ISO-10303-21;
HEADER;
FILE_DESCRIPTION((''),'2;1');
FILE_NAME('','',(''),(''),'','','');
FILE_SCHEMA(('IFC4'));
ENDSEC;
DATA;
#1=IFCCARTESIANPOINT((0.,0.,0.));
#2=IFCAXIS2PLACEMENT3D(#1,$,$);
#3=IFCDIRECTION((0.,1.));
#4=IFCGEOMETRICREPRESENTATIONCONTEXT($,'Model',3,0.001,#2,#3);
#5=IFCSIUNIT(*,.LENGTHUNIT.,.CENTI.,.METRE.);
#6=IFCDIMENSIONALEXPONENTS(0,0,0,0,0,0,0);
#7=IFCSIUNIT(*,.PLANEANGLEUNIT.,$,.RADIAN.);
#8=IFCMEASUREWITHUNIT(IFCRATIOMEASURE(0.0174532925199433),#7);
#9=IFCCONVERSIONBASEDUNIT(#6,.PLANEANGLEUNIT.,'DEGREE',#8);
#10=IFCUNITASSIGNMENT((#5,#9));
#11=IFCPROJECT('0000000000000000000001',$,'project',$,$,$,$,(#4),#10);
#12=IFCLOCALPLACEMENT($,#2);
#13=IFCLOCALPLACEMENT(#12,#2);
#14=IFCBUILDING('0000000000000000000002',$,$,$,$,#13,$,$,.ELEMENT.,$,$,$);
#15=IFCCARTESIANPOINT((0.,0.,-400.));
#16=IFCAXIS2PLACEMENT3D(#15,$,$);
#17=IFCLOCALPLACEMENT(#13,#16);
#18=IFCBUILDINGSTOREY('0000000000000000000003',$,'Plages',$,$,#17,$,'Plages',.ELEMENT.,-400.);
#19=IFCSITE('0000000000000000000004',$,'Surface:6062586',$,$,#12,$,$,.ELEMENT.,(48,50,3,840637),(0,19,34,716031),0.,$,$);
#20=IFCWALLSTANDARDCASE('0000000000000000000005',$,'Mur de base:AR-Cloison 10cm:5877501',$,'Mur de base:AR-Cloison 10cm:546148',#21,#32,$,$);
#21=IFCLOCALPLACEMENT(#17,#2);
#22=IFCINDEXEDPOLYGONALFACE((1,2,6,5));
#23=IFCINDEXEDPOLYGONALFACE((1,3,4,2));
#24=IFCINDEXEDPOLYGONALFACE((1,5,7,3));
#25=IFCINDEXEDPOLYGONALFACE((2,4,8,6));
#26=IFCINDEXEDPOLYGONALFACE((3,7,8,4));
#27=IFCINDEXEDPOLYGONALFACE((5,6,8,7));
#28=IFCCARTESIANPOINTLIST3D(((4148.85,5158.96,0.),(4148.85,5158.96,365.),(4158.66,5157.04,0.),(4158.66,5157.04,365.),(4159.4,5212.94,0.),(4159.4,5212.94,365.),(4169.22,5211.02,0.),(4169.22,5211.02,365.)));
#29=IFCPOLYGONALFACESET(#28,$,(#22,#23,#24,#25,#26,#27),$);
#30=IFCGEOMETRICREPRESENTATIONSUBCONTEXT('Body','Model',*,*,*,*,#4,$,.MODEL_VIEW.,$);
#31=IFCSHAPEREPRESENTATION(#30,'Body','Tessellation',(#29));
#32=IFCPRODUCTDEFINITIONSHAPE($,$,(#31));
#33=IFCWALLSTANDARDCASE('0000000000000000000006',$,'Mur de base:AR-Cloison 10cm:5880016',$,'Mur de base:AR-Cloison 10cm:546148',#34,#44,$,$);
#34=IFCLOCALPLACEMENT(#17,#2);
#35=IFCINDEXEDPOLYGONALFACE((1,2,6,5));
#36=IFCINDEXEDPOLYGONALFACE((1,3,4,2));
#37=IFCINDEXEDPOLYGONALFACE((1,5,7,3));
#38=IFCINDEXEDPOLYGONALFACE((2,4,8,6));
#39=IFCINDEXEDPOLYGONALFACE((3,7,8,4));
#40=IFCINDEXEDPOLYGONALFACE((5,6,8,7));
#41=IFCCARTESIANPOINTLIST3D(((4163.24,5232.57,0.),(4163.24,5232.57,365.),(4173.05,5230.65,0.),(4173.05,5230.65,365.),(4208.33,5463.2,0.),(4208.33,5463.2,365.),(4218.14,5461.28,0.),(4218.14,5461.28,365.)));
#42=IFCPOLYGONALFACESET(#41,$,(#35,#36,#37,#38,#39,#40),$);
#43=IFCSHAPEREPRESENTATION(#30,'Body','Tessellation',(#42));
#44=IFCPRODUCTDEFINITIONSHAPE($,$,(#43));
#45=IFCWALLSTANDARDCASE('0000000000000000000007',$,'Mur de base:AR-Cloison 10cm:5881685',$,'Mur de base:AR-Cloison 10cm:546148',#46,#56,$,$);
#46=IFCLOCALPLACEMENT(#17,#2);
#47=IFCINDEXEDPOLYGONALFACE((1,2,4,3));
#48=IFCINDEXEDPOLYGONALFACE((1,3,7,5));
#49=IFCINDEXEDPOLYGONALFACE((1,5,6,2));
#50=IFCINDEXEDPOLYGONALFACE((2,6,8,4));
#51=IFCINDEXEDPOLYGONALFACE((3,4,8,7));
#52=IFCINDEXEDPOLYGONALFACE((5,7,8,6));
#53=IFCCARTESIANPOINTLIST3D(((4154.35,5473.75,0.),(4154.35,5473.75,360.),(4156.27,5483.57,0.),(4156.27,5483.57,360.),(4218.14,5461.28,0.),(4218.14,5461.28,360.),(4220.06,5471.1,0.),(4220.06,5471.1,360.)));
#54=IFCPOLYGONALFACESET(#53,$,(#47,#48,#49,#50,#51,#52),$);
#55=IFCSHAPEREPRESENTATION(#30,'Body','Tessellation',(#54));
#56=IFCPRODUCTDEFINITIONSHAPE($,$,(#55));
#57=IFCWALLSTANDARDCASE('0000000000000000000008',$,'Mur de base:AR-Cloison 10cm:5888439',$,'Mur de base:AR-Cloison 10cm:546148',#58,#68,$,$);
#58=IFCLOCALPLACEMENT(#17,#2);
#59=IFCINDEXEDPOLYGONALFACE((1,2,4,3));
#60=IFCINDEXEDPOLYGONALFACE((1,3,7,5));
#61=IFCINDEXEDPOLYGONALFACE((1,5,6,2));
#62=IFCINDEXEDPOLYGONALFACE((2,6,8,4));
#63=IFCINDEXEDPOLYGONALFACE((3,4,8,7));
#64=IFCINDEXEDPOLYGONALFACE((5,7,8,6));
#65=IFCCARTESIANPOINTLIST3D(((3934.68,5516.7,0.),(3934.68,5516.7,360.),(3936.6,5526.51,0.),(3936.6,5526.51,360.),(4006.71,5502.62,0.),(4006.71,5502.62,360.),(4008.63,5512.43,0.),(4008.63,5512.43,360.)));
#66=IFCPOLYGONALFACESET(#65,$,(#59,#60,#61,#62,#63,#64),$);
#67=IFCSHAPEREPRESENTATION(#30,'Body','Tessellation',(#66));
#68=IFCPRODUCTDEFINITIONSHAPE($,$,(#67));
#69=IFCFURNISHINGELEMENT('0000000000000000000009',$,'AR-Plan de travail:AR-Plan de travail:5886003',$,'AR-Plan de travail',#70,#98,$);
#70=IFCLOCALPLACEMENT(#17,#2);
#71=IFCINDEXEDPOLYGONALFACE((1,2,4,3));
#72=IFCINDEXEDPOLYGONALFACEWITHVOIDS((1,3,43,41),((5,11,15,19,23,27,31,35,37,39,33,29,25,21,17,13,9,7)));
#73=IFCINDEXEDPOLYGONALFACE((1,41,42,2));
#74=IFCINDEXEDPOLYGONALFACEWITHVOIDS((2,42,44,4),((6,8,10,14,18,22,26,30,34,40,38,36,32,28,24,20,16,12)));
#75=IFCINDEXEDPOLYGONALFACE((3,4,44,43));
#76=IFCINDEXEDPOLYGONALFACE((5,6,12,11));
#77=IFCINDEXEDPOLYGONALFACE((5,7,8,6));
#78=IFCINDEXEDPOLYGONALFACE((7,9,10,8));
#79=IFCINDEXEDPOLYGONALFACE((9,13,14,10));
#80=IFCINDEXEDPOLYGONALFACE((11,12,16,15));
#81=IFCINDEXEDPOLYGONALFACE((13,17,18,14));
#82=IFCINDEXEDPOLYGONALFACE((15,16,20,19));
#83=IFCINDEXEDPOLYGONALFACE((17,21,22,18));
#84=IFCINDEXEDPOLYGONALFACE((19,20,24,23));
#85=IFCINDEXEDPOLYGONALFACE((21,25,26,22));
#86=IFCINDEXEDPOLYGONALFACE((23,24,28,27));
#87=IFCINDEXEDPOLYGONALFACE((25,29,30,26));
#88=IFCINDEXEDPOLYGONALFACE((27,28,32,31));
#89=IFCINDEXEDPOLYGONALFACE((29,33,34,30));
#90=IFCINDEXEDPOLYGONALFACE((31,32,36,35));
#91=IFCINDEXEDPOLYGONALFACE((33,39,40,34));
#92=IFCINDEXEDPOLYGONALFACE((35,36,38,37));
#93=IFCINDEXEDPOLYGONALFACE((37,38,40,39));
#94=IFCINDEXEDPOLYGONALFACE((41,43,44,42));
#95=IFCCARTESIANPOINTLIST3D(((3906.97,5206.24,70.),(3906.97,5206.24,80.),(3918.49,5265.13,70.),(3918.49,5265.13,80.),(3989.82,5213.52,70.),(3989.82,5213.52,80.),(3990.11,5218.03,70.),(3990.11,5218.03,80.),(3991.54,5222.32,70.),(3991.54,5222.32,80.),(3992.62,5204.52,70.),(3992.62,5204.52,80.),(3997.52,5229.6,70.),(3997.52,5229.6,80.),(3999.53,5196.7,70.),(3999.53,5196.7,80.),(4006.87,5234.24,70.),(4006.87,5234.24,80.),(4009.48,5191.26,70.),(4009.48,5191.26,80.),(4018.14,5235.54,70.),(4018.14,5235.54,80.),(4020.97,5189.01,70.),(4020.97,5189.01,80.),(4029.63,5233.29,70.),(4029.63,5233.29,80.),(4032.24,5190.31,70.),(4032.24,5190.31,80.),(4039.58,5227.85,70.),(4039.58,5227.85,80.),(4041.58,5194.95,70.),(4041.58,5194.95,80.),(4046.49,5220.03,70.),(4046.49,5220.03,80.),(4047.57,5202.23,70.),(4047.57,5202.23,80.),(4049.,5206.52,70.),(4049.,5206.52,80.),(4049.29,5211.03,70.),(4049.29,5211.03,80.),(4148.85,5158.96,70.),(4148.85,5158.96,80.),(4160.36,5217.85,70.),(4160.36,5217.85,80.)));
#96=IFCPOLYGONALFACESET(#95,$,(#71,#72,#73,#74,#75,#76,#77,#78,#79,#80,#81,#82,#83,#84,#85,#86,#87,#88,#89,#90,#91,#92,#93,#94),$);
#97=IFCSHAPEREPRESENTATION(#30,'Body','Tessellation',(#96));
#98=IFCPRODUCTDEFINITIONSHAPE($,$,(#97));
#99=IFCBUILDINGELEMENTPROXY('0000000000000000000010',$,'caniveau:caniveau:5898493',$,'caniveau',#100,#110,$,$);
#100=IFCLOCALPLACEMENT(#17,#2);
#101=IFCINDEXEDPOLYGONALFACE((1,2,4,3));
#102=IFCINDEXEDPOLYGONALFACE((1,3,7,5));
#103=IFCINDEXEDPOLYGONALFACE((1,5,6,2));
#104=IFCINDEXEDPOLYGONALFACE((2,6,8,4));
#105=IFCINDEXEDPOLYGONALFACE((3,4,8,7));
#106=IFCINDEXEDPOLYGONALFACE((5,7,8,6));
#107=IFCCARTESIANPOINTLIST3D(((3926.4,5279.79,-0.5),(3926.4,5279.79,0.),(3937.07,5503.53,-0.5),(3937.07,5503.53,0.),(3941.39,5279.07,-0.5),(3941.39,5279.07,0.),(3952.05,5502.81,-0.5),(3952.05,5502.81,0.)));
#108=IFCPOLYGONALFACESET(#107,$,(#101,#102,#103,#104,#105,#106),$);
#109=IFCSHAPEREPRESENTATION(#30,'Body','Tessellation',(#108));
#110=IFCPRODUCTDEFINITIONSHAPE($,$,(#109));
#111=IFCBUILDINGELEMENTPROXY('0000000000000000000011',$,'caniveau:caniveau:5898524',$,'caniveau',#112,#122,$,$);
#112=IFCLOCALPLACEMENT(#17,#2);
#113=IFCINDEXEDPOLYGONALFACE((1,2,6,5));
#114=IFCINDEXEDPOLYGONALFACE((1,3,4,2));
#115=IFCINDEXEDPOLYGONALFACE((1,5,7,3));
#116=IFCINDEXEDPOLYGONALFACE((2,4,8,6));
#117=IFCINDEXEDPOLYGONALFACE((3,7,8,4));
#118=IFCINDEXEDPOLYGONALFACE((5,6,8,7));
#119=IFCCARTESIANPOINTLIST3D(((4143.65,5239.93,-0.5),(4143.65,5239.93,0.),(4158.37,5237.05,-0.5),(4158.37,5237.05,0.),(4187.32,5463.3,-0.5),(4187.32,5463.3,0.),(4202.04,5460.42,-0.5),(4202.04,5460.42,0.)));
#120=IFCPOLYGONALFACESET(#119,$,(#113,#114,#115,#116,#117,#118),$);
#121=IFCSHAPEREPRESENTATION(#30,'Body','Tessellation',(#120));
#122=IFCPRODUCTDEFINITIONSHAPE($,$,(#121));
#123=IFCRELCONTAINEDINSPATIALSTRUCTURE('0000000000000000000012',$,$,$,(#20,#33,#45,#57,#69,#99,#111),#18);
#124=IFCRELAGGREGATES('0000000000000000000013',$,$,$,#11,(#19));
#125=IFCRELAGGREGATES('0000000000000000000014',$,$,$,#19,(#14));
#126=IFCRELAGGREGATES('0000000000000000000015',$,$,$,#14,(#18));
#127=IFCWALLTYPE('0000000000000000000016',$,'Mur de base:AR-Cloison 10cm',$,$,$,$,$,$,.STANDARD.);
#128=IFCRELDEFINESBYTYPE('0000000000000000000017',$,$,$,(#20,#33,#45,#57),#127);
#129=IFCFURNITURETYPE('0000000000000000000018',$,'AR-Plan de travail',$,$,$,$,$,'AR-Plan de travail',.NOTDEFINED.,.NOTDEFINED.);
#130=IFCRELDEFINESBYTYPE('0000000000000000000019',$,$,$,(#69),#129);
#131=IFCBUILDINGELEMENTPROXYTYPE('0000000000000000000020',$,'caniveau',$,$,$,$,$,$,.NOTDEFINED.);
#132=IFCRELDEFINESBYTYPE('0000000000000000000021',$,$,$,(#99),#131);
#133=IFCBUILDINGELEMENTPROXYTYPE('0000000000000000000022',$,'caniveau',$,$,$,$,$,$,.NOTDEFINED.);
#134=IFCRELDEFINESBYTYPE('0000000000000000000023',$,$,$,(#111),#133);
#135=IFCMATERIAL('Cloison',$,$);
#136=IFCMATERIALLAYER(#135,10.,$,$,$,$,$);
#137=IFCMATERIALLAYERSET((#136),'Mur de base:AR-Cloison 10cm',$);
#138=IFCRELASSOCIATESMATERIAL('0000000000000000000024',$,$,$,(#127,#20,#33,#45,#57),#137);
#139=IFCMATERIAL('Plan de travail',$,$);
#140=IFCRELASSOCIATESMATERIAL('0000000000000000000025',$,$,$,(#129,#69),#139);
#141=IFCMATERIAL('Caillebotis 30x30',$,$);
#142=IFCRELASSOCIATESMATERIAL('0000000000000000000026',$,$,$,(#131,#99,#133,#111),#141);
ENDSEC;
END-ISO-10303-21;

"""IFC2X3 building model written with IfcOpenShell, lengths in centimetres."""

from ifc_helpers import new_model, entity, si_unit, converted_unit, direction, frame, frame_2d, origin, origin_2d_with_axis, place, context, subcontext, project, spatial, polyline, rectangle, outline, extrude, source, transform, mapped, material, layer, layer_set, layer_usage, type_object, type_shapes, element, save


model = new_model("IFC2X3")

# Units and contexts
model_context = context("Model", 3, precision=0.001, world=origin(), true_north=direction((0.0, 1.0)))
body_context = subcontext(model_context, "Body", "Model", "MODEL_VIEW")
ifc_project = project(units=[si_unit("LENGTHUNIT", "METRE", prefix="CENTI"), converted_unit("PLANEANGLEUNIT", "DEGREE", entity("IfcRatioMeasure", 0.0174532925199433), si_unit("PLANEANGLEUNIT", "RADIAN"), dimensions=[0, 0, 0, 0, 0, 0, 0])], contexts=[model_context])

# Site, building, storey
site_placement = place(None, origin())
site = spatial("IfcSite", under=ifc_project, at=site_placement, Name="Surface:6062586", CompositionType="ELEMENT", RefLatitude=(48, 50, 3, 840637), RefLongitude=(0, 19, 34, 716031), RefElevation=0.0)
building_placement = place(site_placement, origin())
building = spatial("IfcBuilding", under=site, at=building_placement, CompositionType="ELEMENT")
storey_placement = place(building_placement, frame((0.0, 0.0, -400.0)))
storey = spatial("IfcBuildingStorey", under=building, at=storey_placement, Name="Plages", LongName="Plages", CompositionType="ELEMENT", Elevation=-400.0)

# Walls
ifc_material_1 = material(Name="Cloison")
ifc_layer_1 = layer(ifc_material_1, 10.0)
ifc_layer_set_1 = layer_set([ifc_layer_1], Name="Mur de base:AR-Cloison 10cm")
ifc_layer_usage_1 = layer_usage(ifc_layer_set_1, "AXIS2", "NEGATIVE", 5.0)
wall_type = type_object("IfcWallType", Name="Mur de base:AR-Cloison 10cm", PredefinedType="STANDARD", material=ifc_layer_set_1)
wall_1_placement = place(storey_placement, frame((4164.31, 5211.98, 0.0), z_axis=(0.0, 0.0, 1.0), x_axis=(-0.191861, -0.981422, 0.0)))
element("IfcWallStandardCase", 1, at=wall_1_placement, inside=storey, type_object=wall_type, material=ifc_layer_usage_1, Name="Mur de base:AR-Cloison 10cm:5877501", ObjectType="Mur de base:AR-Cloison 10cm:546148", context=body_context, shape_type="SweptSolid", body=[
    extrude(rectangle(XDim=55.0, YDim=10.0, at=frame_2d((27.5, 0.0), x_axis=(-1.0, 0.0))), origin(), (0.0, 0.0, 1.0), 365.0),
])
ifc_layer_usage_2 = layer_usage(ifc_layer_set_1, "AXIS2", "NEGATIVE", 5.0)
wall_2_placement = place(storey_placement, frame((4168.15, 5231.61, 0.0), z_axis=(0.0, 0.0, 1.0), x_axis=(0.191861, 0.981422, 0.0)))
element("IfcWallStandardCase", 2, at=wall_2_placement, inside=storey, type_object=wall_type, material=ifc_layer_usage_2, Name="Mur de base:AR-Cloison 10cm:5880016", ObjectType="Mur de base:AR-Cloison 10cm:546148", context=body_context, shape_type="SweptSolid", body=[
    extrude(rectangle(XDim=235.0, YDim=10.0, at=frame_2d((117.5, 0.0), x_axis=(-1.0, 0.0))), origin(), (0.0, 0.0, 1.0), 365.0),
])
ifc_layer_usage_3 = layer_usage(ifc_layer_set_1, "AXIS2", "NEGATIVE", 5.0)
wall_3_placement = place(storey_placement, frame((4219.1, 5466.19, 0.0), z_axis=(0.0, 0.0, 1.0), x_axis=(-0.981422, 0.191861, 0.0)))
element("IfcWallStandardCase", 3, at=wall_3_placement, inside=storey, type_object=wall_type, material=ifc_layer_usage_3, Name="Mur de base:AR-Cloison 10cm:5881685", ObjectType="Mur de base:AR-Cloison 10cm:546148", context=body_context, shape_type="SweptSolid", body=[
    extrude(rectangle(XDim=65.0, YDim=10.0, at=frame_2d((32.5, 0.0), x_axis=(-1.0, 0.0))), origin(), (0.0, 0.0, 1.0), 360.0),
])
ifc_layer_usage_4 = layer_usage(ifc_layer_set_1, "AXIS2", "NEGATIVE", 5.0)
wall_4_placement = place(storey_placement, frame((4007.67, 5507.52, 0.0), z_axis=(0.0, 0.0, 1.0), x_axis=(-0.981422, 0.191861, 0.0)))
element("IfcWallStandardCase", 4, at=wall_4_placement, inside=storey, type_object=wall_type, material=ifc_layer_usage_4, Name="Mur de base:AR-Cloison 10cm:5888439", ObjectType="Mur de base:AR-Cloison 10cm:546148", context=body_context, shape_type="SweptSolid", body=[
    extrude(rectangle(XDim=73.39, YDim=10.0, at=frame_2d((36.7, 0.0), x_axis=(-1.0, 0.0))), origin(), (0.0, 0.0, 1.0), 360.0),
])

# Furnishing element
ifc_material_2 = material(Name="Plan de travail")
furniture_type_1 = type_object("IfcFurnitureType", Name="AR-Plan de travail", ElementType="AR-Plan de travail", material=ifc_material_2)
shared_shape_1 = source(origin(), body_context, "Body", "SweptSolid", [
    extrude(outline(polyline([(-123.23, -30.0), (123.23, -30.0), (123.23, 30.0), (-123.23, 30.0), (-123.23, -30.0)]), holes=[polyline([(-43.9, -2.48), (-43.32, 2.0), (-38.84, 10.3), (-30.56, 16.64), (-19.75, 20.08), (-8.04, 20.08), (2.77, 16.64), (11.05, 10.3), (15.53, 2.0), (16.1, -2.48), (15.53, -6.97), (11.05, -15.26), (2.77, -21.61), (-8.04, -25.04), (-19.75, -25.04), (-30.56, -21.61), (-38.84, -15.26), (-43.32, -6.97), (-43.9, -2.48)])]), frame((126.69, 53.09, 0.0), z_axis=(0.0, 0.0, 1.0), x_axis=(0.981422, -0.191861, 0.0)), (0.0, 0.0, 1.0), 10.0),
])
type_shapes(furniture_type_1, [shared_shape_1])
furnishing_1_placement = place(storey_placement, frame((3906.97, 5158.96, 70.0)))
element("IfcFurnishingElement", 5, at=furnishing_1_placement, inside=storey, type_object=furniture_type_1, material=ifc_material_2, Name="AR-Plan de travail:AR-Plan de travail:5886003", ObjectType="AR-Plan de travail", context=body_context, shape_type="MappedRepresentation", body=[
    mapped(shared_shape_1, transform((0.0, 0.0, 0.0), scale=1.0)),
])

# Building element proxies
ifc_material_3 = material(Name="Caillebotis 30x30")
building_element_proxy_type_1 = type_object("IfcBuildingElementProxyType", Name="caniveau", PredefinedType="NOTDEFINED", material=ifc_material_3)
shared_shape_2 = source(origin(), body_context, "Body", "SweptSolid", [
    extrude(rectangle(XDim=15.0, YDim=224.0, at=origin_2d_with_axis()), frame((112.0, 7.5, -0.5), z_axis=(0.0, 0.0, 1.0), x_axis=(0.0, 1.0, 0.0)), (0.0, 0.0, 1.0), 0.5),
])
type_shapes(building_element_proxy_type_1, [shared_shape_2])
proxy_1_placement = place(storey_placement, frame((3937.07, 5503.53, 0.0), z_axis=(0.0, 0.0, 1.0), x_axis=(-0.047601, -0.998866, 0.0)))
element("IfcBuildingElementProxy", 6, at=proxy_1_placement, inside=storey, type_object=building_element_proxy_type_1, material=ifc_material_3, Name="caniveau:caniveau:5898493", ObjectType="caniveau", context=body_context, shape_type="MappedRepresentation", body=[
    mapped(shared_shape_2, transform((0.0, 0.0, 0.0), scale=1.0)),
])
building_element_proxy_type_2 = type_object("IfcBuildingElementProxyType", Name="caniveau", PredefinedType="NOTDEFINED", material=ifc_material_3)
shared_shape_3 = source(origin(), body_context, "Body", "SweptSolid", [
    extrude(rectangle(XDim=15.0, YDim=227.6, at=origin_2d_with_axis()), frame((113.8, 7.5, -0.5), z_axis=(0.0, 0.0, 1.0), x_axis=(0.0, 1.0, 0.0)), (0.0, 0.0, 1.0), 0.5),
])
type_shapes(building_element_proxy_type_2, [shared_shape_3])
proxy_2_placement = place(storey_placement, frame((4158.37, 5237.05, 0.0), z_axis=(0.0, 0.0, 1.0), x_axis=(0.191861, 0.981422, 0.0)))
element("IfcBuildingElementProxy", 7, at=proxy_2_placement, inside=storey, type_object=building_element_proxy_type_2, material=ifc_material_3, Name="caniveau:caniveau:5898524", ObjectType="caniveau", context=body_context, shape_type="MappedRepresentation", body=[
    mapped(shared_shape_3, transform((0.0, 0.0, 0.0), scale=1.0)),
])

save(model, "model.ifc")
